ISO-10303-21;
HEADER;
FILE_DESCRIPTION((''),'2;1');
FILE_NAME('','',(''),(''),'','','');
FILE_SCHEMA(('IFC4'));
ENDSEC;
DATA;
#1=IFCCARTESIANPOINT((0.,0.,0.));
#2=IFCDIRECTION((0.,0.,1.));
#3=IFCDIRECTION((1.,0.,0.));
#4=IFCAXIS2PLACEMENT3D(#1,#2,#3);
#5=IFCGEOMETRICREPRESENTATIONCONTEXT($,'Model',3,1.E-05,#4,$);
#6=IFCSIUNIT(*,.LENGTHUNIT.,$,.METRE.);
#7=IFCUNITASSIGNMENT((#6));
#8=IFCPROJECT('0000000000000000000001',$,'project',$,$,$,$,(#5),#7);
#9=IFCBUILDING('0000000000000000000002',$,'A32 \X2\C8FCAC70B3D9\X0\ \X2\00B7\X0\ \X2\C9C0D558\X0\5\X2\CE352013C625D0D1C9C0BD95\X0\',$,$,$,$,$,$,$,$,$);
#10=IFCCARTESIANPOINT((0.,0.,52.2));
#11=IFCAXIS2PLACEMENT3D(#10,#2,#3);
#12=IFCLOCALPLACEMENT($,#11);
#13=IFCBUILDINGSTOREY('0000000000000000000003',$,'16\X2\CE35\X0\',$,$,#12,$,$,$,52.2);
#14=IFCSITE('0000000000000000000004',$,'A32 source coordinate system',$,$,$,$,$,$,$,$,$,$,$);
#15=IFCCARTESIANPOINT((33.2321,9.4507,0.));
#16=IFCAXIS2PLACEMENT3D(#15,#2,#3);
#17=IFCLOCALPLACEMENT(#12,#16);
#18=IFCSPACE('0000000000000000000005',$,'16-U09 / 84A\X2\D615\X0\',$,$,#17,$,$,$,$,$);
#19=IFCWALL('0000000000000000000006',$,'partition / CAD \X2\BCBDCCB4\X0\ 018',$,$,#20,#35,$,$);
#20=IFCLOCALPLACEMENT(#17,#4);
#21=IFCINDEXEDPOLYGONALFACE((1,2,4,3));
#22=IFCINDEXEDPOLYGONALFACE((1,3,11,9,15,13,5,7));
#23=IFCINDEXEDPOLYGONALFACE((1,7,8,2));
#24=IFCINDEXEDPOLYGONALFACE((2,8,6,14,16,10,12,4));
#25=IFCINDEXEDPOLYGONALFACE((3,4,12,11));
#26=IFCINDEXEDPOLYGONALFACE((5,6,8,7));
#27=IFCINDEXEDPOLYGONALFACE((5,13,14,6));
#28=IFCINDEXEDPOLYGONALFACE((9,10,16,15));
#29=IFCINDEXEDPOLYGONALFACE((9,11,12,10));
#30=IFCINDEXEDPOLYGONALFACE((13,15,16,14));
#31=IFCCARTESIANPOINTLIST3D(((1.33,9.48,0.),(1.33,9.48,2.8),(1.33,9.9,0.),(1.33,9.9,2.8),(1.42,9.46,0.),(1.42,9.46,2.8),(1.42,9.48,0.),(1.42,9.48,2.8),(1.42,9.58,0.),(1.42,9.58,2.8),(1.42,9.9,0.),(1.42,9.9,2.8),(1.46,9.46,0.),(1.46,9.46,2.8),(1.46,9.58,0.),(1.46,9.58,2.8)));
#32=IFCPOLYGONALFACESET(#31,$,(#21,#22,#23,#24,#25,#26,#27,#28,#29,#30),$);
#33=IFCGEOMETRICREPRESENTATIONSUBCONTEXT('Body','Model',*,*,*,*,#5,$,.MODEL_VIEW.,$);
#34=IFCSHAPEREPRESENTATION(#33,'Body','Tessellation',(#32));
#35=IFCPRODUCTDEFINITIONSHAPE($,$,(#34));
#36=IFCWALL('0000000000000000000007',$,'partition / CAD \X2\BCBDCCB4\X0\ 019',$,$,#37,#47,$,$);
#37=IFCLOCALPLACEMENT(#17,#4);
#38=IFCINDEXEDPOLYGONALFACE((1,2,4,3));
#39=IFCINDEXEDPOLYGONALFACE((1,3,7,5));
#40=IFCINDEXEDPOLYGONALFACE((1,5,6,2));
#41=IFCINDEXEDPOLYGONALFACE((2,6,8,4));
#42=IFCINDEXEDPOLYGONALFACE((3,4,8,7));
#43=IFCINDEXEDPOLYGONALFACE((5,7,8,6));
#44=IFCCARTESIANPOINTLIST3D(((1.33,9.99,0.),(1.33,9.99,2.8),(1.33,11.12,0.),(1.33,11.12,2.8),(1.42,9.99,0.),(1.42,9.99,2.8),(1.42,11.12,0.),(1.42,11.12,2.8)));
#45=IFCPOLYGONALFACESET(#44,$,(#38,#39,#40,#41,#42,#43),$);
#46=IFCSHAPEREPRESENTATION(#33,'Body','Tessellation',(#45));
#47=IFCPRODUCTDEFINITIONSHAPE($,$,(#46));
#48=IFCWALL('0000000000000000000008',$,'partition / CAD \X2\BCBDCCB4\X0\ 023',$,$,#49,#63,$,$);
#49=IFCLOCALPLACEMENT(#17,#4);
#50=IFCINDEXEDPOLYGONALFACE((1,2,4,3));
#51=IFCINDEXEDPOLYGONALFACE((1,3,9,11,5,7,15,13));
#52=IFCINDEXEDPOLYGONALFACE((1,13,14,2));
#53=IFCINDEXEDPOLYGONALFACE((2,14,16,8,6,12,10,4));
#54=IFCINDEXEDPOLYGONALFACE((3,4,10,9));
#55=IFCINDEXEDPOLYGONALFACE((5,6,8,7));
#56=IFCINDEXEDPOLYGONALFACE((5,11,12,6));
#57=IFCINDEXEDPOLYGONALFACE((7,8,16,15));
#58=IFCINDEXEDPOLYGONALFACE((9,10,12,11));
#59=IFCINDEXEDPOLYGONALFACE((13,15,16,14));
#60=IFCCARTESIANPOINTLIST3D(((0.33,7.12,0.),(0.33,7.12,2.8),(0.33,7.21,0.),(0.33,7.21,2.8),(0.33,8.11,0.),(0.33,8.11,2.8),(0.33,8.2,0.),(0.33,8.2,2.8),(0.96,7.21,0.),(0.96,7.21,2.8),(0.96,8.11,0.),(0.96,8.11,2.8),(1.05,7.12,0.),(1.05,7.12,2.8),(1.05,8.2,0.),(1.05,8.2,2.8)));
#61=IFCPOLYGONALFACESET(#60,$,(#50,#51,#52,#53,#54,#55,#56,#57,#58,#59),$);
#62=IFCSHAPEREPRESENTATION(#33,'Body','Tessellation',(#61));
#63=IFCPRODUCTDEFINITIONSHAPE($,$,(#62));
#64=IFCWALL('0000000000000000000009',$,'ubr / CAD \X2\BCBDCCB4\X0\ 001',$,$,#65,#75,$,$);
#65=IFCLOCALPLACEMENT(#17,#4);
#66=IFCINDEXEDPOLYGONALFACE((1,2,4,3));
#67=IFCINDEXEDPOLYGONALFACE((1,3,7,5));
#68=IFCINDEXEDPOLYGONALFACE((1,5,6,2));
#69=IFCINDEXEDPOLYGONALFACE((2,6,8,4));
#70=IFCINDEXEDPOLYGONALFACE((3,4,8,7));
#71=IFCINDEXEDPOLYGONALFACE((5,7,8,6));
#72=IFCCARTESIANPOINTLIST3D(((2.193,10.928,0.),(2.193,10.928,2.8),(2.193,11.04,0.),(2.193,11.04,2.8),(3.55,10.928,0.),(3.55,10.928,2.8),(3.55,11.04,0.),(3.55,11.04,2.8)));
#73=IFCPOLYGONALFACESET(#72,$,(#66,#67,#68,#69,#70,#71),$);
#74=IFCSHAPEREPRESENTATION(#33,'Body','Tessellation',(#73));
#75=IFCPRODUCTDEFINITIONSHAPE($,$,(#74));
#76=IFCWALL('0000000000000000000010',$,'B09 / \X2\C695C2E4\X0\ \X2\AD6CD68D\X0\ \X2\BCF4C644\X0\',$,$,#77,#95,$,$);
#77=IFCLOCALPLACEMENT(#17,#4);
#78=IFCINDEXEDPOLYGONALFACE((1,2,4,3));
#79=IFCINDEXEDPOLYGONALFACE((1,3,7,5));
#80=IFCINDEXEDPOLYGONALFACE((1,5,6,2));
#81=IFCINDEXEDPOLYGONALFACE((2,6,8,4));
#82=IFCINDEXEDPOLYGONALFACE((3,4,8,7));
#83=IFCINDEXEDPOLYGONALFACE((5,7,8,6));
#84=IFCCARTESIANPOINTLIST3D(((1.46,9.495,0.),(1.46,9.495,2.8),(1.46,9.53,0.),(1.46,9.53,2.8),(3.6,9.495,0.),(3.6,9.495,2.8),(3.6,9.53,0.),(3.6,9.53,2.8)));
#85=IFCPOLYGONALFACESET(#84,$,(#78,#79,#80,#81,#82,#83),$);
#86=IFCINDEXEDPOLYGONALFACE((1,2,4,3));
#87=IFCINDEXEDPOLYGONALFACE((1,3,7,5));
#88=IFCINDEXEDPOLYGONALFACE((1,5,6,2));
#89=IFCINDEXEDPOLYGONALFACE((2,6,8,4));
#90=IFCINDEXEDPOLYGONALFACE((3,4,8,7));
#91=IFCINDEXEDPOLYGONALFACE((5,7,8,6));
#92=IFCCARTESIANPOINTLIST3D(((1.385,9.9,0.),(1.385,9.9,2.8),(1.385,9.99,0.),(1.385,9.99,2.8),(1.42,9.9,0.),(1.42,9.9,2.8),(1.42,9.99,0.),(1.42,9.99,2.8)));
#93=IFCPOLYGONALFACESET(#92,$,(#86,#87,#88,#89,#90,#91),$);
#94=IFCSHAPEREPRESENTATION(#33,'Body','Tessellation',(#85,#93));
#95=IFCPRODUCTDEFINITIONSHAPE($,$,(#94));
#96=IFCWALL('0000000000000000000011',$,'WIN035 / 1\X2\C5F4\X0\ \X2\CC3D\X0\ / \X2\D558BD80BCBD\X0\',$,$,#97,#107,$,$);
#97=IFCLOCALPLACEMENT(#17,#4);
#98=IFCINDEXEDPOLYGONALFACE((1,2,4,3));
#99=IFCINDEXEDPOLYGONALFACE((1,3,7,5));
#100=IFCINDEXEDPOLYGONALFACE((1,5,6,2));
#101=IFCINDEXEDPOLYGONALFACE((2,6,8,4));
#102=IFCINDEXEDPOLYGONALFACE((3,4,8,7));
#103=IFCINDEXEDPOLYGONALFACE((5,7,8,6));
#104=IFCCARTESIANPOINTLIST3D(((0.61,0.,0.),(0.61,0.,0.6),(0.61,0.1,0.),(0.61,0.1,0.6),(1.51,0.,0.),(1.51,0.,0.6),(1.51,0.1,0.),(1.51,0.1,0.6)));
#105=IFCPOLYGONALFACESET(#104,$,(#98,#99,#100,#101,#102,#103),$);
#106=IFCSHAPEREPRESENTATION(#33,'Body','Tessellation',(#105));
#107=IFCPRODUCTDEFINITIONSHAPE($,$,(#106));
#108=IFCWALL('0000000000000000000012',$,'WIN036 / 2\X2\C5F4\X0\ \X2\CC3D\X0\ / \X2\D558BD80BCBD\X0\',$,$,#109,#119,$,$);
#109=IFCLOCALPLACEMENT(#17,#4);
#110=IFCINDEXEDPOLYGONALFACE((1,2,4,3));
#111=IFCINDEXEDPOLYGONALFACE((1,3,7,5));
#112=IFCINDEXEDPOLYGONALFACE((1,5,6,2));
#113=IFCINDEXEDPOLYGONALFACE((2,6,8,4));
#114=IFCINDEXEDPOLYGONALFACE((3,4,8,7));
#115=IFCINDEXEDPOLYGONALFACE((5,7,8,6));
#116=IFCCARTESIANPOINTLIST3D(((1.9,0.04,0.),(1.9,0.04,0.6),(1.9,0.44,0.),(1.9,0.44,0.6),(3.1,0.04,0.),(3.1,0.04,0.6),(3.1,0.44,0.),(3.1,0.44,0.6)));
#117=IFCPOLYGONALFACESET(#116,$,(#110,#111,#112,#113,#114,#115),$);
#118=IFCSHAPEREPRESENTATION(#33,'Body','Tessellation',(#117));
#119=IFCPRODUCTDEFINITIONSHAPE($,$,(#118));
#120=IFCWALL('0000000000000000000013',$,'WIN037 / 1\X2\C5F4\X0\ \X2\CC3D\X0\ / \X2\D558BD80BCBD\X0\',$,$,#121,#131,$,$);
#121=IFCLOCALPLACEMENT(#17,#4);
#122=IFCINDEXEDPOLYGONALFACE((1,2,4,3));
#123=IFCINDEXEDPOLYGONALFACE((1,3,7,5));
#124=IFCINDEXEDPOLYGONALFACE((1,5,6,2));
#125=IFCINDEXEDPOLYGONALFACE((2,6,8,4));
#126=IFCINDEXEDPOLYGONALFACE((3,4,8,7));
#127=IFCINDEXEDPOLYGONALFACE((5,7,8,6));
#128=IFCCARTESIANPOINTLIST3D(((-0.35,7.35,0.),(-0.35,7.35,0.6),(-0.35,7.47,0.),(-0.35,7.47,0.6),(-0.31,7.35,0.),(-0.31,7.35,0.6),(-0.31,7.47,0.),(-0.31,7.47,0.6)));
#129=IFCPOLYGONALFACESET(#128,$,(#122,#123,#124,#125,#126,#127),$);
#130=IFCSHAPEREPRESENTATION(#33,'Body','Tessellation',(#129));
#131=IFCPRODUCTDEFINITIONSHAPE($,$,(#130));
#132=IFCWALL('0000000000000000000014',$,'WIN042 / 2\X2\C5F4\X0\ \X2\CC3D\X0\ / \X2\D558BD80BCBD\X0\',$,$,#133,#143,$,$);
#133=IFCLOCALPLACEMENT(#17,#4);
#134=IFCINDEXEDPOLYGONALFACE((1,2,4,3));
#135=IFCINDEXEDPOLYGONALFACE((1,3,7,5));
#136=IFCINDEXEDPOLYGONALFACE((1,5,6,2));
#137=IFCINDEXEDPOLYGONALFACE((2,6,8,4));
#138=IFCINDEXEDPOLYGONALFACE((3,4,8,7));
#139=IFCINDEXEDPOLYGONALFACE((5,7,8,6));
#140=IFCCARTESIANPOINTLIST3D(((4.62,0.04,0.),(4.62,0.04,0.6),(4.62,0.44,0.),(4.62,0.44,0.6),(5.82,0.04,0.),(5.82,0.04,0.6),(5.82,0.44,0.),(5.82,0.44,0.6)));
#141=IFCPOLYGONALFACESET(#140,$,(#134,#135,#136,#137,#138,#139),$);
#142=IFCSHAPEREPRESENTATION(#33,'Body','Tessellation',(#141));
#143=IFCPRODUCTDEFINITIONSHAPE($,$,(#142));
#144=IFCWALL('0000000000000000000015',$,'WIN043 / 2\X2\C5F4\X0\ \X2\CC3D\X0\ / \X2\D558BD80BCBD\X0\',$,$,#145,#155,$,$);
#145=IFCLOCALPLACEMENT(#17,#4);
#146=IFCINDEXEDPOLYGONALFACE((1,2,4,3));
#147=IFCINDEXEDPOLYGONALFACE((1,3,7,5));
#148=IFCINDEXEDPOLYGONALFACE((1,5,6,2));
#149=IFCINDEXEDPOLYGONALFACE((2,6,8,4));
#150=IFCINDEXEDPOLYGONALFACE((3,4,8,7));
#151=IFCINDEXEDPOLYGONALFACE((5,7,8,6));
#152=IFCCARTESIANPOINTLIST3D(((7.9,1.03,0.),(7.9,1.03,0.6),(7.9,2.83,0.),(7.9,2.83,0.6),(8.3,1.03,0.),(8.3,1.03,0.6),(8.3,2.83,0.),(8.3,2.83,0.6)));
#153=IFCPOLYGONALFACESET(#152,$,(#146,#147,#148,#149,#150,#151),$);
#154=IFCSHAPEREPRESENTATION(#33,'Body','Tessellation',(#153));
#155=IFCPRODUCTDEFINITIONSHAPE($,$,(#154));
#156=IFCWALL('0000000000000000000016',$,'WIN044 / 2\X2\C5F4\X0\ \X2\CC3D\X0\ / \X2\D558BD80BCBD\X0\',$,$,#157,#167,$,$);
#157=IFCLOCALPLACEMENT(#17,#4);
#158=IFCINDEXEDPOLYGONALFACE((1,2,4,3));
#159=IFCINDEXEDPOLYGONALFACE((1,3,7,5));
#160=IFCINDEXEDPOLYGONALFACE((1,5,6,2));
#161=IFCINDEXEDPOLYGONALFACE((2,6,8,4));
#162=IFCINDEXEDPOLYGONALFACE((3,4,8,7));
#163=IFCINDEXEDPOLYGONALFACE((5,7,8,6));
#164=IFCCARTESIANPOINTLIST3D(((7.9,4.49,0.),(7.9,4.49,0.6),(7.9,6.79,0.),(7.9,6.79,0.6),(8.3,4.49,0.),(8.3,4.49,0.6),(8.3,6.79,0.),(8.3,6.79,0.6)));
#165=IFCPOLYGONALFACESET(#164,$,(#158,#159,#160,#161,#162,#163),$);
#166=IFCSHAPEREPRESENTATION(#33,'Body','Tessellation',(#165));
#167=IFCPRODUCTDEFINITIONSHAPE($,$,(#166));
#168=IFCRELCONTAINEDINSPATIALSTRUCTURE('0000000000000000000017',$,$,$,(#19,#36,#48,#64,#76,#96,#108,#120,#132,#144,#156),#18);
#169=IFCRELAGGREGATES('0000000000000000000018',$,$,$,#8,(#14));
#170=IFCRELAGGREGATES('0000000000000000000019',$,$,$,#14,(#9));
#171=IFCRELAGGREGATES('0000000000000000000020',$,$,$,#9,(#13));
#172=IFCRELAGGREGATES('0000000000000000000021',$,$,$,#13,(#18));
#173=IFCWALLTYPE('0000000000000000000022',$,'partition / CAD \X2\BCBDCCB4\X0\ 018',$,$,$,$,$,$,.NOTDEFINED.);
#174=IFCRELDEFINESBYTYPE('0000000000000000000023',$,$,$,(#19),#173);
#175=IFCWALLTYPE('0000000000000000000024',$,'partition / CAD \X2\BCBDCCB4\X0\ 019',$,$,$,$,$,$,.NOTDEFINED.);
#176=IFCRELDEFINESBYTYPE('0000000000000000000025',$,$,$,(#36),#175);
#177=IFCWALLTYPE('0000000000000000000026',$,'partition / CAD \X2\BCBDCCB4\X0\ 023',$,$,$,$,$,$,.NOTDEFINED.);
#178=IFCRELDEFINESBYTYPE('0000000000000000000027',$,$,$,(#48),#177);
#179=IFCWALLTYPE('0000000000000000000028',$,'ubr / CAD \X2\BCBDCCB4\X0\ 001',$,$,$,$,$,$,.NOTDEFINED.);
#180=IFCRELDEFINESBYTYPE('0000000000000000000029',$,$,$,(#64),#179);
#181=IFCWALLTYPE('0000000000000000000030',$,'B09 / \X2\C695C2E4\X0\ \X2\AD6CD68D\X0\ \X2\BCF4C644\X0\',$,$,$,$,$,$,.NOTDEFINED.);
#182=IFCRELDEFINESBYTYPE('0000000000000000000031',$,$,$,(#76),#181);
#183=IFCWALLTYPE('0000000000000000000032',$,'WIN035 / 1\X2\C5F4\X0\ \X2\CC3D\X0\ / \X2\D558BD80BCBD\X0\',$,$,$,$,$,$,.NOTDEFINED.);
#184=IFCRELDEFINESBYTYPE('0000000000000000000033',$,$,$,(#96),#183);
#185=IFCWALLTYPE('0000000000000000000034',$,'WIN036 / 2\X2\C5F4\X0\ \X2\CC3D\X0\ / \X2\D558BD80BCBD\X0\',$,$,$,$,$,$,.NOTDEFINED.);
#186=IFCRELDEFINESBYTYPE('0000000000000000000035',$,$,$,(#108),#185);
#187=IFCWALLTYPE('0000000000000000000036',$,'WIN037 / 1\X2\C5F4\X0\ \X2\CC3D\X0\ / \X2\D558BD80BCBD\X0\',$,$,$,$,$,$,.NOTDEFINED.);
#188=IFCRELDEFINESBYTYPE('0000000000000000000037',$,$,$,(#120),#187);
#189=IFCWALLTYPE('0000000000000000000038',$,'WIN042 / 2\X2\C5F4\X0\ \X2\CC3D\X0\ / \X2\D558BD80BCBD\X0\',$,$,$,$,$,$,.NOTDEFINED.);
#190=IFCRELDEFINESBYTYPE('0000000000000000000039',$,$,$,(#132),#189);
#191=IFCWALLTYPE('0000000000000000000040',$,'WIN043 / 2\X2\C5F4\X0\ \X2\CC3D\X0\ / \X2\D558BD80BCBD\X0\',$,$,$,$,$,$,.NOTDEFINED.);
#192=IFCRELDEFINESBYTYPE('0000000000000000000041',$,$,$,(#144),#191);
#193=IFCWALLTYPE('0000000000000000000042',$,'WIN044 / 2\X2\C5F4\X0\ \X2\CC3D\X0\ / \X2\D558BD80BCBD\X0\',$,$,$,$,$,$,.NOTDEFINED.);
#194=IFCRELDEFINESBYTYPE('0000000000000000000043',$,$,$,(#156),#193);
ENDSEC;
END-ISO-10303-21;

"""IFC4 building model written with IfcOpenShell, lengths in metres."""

from ifc_helpers import new_model, si_unit, frame, origin, origin_with_axes, place, context, subcontext, project, spatial, polyline, outline, extrude, source, transform, mapped, type_object, type_shapes, element, save


model = new_model("IFC4")

# Units and contexts
model_context = context("Model", 3, precision=1e-05, world=origin_with_axes())
body_context = subcontext(model_context, "Body", "Model", "MODEL_VIEW")
ifc_project = project(units=[si_unit("LENGTHUNIT", "METRE")], contexts=[model_context])

# Site, building, storey, space
site = spatial("IfcSite", under=ifc_project, Name="A32 source coordinate system")
building = spatial("IfcBuilding", under=site, Name="A32 주거동 · 지하5층–옥탑지붕")
storey_placement = place(None, frame((0.0, 0.0, 52.2), z_axis=(0.0, 0.0, 1.0), x_axis=(1.0, 0.0, 0.0)))
storey = spatial("IfcBuildingStorey", under=building, at=storey_placement, Name="16층", Elevation=52.2)
space_1_placement = place(storey_placement, frame((33.2321, 9.4507, 0.0), z_axis=(0.0, 0.0, 1.0), x_axis=(1.0, 0.0, 0.0)))
space_1 = spatial("IfcSpace", under=storey, at=space_1_placement, Name="16-U09 / 84A형")

# Walls
wall_type_1 = type_object("IfcWallType", Name="partition / CAD 벽체 018", PredefinedType="NOTDEFINED")
shared_shape_1 = source(origin(), body_context, "Body", "SweptSolid", [
    extrude(outline(polyline([(1.42, 9.58), (1.46, 9.58), (1.46, 9.46), (1.42, 9.46), (1.42, 9.48), (1.33, 9.48), (1.33, 9.9), (1.42, 9.9), (1.42, 9.58)])), origin(), (0.0, 0.0, 1.0), 2.8),
])
type_shapes(wall_type_1, [shared_shape_1])
wall_1_placement = place(space_1_placement, origin_with_axes())
element("IfcWall", 1, at=wall_1_placement, inside=space_1, type_object=wall_type_1, Name="partition / CAD 벽체 018", context=body_context, shape_type="MappedRepresentation", body=[
    mapped(shared_shape_1, transform((0.0, 0.0, 0.0), scale=1.0)),
])
wall_type_2 = type_object("IfcWallType", Name="partition / CAD 벽체 019", PredefinedType="NOTDEFINED")
shared_shape_2 = source(origin(), body_context, "Body", "SweptSolid", [
    extrude(outline(polyline([(1.33, 11.12), (1.42, 11.12), (1.42, 9.99), (1.33, 9.99), (1.33, 11.12)])), origin(), (0.0, 0.0, 1.0), 2.8),
])
type_shapes(wall_type_2, [shared_shape_2])
wall_2_placement = place(space_1_placement, origin_with_axes())
element("IfcWall", 2, at=wall_2_placement, inside=space_1, type_object=wall_type_2, Name="partition / CAD 벽체 019", context=body_context, shape_type="MappedRepresentation", body=[
    mapped(shared_shape_2, transform((0.0, 0.0, 0.0), scale=1.0)),
])
wall_type_3 = type_object("IfcWallType", Name="partition / CAD 벽체 023", PredefinedType="NOTDEFINED")
shared_shape_3 = source(origin(), body_context, "Body", "SweptSolid", [
    extrude(outline(polyline([(0.96, 8.11), (0.33, 8.11), (0.33, 8.2), (1.05, 8.2), (1.05, 7.12), (0.33, 7.12), (0.33, 7.21), (0.96, 7.21), (0.96, 8.11)])), origin(), (0.0, 0.0, 1.0), 2.8),
])
type_shapes(wall_type_3, [shared_shape_3])
wall_3_placement = place(space_1_placement, origin_with_axes())
element("IfcWall", 3, at=wall_3_placement, inside=space_1, type_object=wall_type_3, Name="partition / CAD 벽체 023", context=body_context, shape_type="MappedRepresentation", body=[
    mapped(shared_shape_3, transform((0.0, 0.0, 0.0), scale=1.0)),
])
wall_type_4 = type_object("IfcWallType", Name="ubr / CAD 벽체 001", PredefinedType="NOTDEFINED")
shared_shape_4 = source(origin(), body_context, "Body", "SweptSolid", [
    extrude(outline(polyline([(3.55, 11.04), (3.55, 10.928), (2.193, 10.928), (2.193, 11.04), (3.55, 11.04)])), origin(), (0.0, 0.0, 1.0), 2.8),
])
type_shapes(wall_type_4, [shared_shape_4])
wall_4_placement = place(space_1_placement, origin_with_axes())
element("IfcWall", 4, at=wall_4_placement, inside=space_1, type_object=wall_type_4, Name="ubr / CAD 벽체 001", context=body_context, shape_type="MappedRepresentation", body=[
    mapped(shared_shape_4, transform((0.0, 0.0, 0.0), scale=1.0)),
])
wall_type_5 = type_object("IfcWallType", Name="B09 / 욕실 구획 보완", PredefinedType="NOTDEFINED")
shared_shape_5 = source(origin(), body_context, "Body", "SweptSolid", [
    extrude(outline(polyline([(3.6, 9.53), (3.6, 9.495), (1.46, 9.495), (1.46, 9.53), (3.6, 9.53)])), origin(), (0.0, 0.0, 1.0), 2.8),
    extrude(outline(polyline([(1.42, 9.9), (1.385, 9.9), (1.385, 9.99), (1.42, 9.99), (1.42, 9.9)])), origin(), (0.0, 0.0, 1.0), 2.8),
])
type_shapes(wall_type_5, [shared_shape_5])
wall_5_placement = place(space_1_placement, origin_with_axes())
element("IfcWall", 5, at=wall_5_placement, inside=space_1, type_object=wall_type_5, Name="B09 / 욕실 구획 보완", context=body_context, shape_type="MappedRepresentation", body=[
    mapped(shared_shape_5, transform((0.0, 0.0, 0.0), scale=1.0)),
])
wall_type_6 = type_object("IfcWallType", Name="WIN035 / 1열 창 / 하부벽", PredefinedType="NOTDEFINED")
shared_shape_6 = source(origin(), body_context, "Body", "SweptSolid", [
    extrude(outline(polyline([(0.61, 0.1), (1.51, 0.1), (1.51, 0.0), (0.61, 0.0), (0.61, 0.1)])), origin(), (0.0, 0.0, 1.0), 0.6),
])
type_shapes(wall_type_6, [shared_shape_6])
wall_6_placement = place(space_1_placement, origin_with_axes())
element("IfcWall", 6, at=wall_6_placement, inside=space_1, type_object=wall_type_6, Name="WIN035 / 1열 창 / 하부벽", context=body_context, shape_type="MappedRepresentation", body=[
    mapped(shared_shape_6, transform((0.0, 0.0, 0.0), scale=1.0)),
])
wall_type_7 = type_object("IfcWallType", Name="WIN036 / 2열 창 / 하부벽", PredefinedType="NOTDEFINED")
shared_shape_7 = source(origin(), body_context, "Body", "SweptSolid", [
    extrude(outline(polyline([(1.9, 0.44), (3.1, 0.44), (3.1, 0.04), (1.9, 0.04), (1.9, 0.44)])), origin(), (0.0, 0.0, 1.0), 0.6),
])
type_shapes(wall_type_7, [shared_shape_7])
wall_7_placement = place(space_1_placement, origin_with_axes())
element("IfcWall", 7, at=wall_7_placement, inside=space_1, type_object=wall_type_7, Name="WIN036 / 2열 창 / 하부벽", context=body_context, shape_type="MappedRepresentation", body=[
    mapped(shared_shape_7, transform((0.0, 0.0, 0.0), scale=1.0)),
])
wall_type_8 = type_object("IfcWallType", Name="WIN037 / 1열 창 / 하부벽", PredefinedType="NOTDEFINED")
shared_shape_8 = source(origin(), body_context, "Body", "SweptSolid", [
    extrude(outline(polyline([(-0.31, 7.47), (-0.31, 7.35), (-0.35, 7.35), (-0.35, 7.47), (-0.31, 7.47)])), origin(), (0.0, 0.0, 1.0), 0.6),
])
type_shapes(wall_type_8, [shared_shape_8])
wall_8_placement = place(space_1_placement, origin_with_axes())
element("IfcWall", 8, at=wall_8_placement, inside=space_1, type_object=wall_type_8, Name="WIN037 / 1열 창 / 하부벽", context=body_context, shape_type="MappedRepresentation", body=[
    mapped(shared_shape_8, transform((0.0, 0.0, 0.0), scale=1.0)),
])
wall_type_9 = type_object("IfcWallType", Name="WIN042 / 2열 창 / 하부벽", PredefinedType="NOTDEFINED")
shared_shape_9 = source(origin(), body_context, "Body", "SweptSolid", [
    extrude(outline(polyline([(4.62, 0.44), (5.82, 0.44), (5.82, 0.04), (4.62, 0.04), (4.62, 0.44)])), origin(), (0.0, 0.0, 1.0), 0.6),
])
type_shapes(wall_type_9, [shared_shape_9])
wall_9_placement = place(space_1_placement, origin_with_axes())
element("IfcWall", 9, at=wall_9_placement, inside=space_1, type_object=wall_type_9, Name="WIN042 / 2열 창 / 하부벽", context=body_context, shape_type="MappedRepresentation", body=[
    mapped(shared_shape_9, transform((0.0, 0.0, 0.0), scale=1.0)),
])
wall_type_10 = type_object("IfcWallType", Name="WIN043 / 2열 창 / 하부벽", PredefinedType="NOTDEFINED")
shared_shape_10 = source(origin(), body_context, "Body", "SweptSolid", [
    extrude(outline(polyline([(7.9, 2.83), (8.3, 2.83), (8.3, 1.03), (7.9, 1.03), (7.9, 2.83)])), origin(), (0.0, 0.0, 1.0), 0.6),
])
type_shapes(wall_type_10, [shared_shape_10])
wall_10_placement = place(space_1_placement, origin_with_axes())
element("IfcWall", 10, at=wall_10_placement, inside=space_1, type_object=wall_type_10, Name="WIN043 / 2열 창 / 하부벽", context=body_context, shape_type="MappedRepresentation", body=[
    mapped(shared_shape_10, transform((0.0, 0.0, 0.0), scale=1.0)),
])
wall_type_11 = type_object("IfcWallType", Name="WIN044 / 2열 창 / 하부벽", PredefinedType="NOTDEFINED")
shared_shape_11 = source(origin(), body_context, "Body", "SweptSolid", [
    extrude(outline(polyline([(7.9, 6.79), (8.3, 6.79), (8.3, 4.49), (7.9, 4.49), (7.9, 6.79)])), origin(), (0.0, 0.0, 1.0), 0.6),
])
type_shapes(wall_type_11, [shared_shape_11])
wall_11_placement = place(space_1_placement, origin_with_axes())
element("IfcWall", 11, at=wall_11_placement, inside=space_1, type_object=wall_type_11, Name="WIN044 / 2열 창 / 하부벽", context=body_context, shape_type="MappedRepresentation", body=[
    mapped(shared_shape_11, transform((0.0, 0.0, 0.0), scale=1.0)),
])

save(model, "model.ifc")
